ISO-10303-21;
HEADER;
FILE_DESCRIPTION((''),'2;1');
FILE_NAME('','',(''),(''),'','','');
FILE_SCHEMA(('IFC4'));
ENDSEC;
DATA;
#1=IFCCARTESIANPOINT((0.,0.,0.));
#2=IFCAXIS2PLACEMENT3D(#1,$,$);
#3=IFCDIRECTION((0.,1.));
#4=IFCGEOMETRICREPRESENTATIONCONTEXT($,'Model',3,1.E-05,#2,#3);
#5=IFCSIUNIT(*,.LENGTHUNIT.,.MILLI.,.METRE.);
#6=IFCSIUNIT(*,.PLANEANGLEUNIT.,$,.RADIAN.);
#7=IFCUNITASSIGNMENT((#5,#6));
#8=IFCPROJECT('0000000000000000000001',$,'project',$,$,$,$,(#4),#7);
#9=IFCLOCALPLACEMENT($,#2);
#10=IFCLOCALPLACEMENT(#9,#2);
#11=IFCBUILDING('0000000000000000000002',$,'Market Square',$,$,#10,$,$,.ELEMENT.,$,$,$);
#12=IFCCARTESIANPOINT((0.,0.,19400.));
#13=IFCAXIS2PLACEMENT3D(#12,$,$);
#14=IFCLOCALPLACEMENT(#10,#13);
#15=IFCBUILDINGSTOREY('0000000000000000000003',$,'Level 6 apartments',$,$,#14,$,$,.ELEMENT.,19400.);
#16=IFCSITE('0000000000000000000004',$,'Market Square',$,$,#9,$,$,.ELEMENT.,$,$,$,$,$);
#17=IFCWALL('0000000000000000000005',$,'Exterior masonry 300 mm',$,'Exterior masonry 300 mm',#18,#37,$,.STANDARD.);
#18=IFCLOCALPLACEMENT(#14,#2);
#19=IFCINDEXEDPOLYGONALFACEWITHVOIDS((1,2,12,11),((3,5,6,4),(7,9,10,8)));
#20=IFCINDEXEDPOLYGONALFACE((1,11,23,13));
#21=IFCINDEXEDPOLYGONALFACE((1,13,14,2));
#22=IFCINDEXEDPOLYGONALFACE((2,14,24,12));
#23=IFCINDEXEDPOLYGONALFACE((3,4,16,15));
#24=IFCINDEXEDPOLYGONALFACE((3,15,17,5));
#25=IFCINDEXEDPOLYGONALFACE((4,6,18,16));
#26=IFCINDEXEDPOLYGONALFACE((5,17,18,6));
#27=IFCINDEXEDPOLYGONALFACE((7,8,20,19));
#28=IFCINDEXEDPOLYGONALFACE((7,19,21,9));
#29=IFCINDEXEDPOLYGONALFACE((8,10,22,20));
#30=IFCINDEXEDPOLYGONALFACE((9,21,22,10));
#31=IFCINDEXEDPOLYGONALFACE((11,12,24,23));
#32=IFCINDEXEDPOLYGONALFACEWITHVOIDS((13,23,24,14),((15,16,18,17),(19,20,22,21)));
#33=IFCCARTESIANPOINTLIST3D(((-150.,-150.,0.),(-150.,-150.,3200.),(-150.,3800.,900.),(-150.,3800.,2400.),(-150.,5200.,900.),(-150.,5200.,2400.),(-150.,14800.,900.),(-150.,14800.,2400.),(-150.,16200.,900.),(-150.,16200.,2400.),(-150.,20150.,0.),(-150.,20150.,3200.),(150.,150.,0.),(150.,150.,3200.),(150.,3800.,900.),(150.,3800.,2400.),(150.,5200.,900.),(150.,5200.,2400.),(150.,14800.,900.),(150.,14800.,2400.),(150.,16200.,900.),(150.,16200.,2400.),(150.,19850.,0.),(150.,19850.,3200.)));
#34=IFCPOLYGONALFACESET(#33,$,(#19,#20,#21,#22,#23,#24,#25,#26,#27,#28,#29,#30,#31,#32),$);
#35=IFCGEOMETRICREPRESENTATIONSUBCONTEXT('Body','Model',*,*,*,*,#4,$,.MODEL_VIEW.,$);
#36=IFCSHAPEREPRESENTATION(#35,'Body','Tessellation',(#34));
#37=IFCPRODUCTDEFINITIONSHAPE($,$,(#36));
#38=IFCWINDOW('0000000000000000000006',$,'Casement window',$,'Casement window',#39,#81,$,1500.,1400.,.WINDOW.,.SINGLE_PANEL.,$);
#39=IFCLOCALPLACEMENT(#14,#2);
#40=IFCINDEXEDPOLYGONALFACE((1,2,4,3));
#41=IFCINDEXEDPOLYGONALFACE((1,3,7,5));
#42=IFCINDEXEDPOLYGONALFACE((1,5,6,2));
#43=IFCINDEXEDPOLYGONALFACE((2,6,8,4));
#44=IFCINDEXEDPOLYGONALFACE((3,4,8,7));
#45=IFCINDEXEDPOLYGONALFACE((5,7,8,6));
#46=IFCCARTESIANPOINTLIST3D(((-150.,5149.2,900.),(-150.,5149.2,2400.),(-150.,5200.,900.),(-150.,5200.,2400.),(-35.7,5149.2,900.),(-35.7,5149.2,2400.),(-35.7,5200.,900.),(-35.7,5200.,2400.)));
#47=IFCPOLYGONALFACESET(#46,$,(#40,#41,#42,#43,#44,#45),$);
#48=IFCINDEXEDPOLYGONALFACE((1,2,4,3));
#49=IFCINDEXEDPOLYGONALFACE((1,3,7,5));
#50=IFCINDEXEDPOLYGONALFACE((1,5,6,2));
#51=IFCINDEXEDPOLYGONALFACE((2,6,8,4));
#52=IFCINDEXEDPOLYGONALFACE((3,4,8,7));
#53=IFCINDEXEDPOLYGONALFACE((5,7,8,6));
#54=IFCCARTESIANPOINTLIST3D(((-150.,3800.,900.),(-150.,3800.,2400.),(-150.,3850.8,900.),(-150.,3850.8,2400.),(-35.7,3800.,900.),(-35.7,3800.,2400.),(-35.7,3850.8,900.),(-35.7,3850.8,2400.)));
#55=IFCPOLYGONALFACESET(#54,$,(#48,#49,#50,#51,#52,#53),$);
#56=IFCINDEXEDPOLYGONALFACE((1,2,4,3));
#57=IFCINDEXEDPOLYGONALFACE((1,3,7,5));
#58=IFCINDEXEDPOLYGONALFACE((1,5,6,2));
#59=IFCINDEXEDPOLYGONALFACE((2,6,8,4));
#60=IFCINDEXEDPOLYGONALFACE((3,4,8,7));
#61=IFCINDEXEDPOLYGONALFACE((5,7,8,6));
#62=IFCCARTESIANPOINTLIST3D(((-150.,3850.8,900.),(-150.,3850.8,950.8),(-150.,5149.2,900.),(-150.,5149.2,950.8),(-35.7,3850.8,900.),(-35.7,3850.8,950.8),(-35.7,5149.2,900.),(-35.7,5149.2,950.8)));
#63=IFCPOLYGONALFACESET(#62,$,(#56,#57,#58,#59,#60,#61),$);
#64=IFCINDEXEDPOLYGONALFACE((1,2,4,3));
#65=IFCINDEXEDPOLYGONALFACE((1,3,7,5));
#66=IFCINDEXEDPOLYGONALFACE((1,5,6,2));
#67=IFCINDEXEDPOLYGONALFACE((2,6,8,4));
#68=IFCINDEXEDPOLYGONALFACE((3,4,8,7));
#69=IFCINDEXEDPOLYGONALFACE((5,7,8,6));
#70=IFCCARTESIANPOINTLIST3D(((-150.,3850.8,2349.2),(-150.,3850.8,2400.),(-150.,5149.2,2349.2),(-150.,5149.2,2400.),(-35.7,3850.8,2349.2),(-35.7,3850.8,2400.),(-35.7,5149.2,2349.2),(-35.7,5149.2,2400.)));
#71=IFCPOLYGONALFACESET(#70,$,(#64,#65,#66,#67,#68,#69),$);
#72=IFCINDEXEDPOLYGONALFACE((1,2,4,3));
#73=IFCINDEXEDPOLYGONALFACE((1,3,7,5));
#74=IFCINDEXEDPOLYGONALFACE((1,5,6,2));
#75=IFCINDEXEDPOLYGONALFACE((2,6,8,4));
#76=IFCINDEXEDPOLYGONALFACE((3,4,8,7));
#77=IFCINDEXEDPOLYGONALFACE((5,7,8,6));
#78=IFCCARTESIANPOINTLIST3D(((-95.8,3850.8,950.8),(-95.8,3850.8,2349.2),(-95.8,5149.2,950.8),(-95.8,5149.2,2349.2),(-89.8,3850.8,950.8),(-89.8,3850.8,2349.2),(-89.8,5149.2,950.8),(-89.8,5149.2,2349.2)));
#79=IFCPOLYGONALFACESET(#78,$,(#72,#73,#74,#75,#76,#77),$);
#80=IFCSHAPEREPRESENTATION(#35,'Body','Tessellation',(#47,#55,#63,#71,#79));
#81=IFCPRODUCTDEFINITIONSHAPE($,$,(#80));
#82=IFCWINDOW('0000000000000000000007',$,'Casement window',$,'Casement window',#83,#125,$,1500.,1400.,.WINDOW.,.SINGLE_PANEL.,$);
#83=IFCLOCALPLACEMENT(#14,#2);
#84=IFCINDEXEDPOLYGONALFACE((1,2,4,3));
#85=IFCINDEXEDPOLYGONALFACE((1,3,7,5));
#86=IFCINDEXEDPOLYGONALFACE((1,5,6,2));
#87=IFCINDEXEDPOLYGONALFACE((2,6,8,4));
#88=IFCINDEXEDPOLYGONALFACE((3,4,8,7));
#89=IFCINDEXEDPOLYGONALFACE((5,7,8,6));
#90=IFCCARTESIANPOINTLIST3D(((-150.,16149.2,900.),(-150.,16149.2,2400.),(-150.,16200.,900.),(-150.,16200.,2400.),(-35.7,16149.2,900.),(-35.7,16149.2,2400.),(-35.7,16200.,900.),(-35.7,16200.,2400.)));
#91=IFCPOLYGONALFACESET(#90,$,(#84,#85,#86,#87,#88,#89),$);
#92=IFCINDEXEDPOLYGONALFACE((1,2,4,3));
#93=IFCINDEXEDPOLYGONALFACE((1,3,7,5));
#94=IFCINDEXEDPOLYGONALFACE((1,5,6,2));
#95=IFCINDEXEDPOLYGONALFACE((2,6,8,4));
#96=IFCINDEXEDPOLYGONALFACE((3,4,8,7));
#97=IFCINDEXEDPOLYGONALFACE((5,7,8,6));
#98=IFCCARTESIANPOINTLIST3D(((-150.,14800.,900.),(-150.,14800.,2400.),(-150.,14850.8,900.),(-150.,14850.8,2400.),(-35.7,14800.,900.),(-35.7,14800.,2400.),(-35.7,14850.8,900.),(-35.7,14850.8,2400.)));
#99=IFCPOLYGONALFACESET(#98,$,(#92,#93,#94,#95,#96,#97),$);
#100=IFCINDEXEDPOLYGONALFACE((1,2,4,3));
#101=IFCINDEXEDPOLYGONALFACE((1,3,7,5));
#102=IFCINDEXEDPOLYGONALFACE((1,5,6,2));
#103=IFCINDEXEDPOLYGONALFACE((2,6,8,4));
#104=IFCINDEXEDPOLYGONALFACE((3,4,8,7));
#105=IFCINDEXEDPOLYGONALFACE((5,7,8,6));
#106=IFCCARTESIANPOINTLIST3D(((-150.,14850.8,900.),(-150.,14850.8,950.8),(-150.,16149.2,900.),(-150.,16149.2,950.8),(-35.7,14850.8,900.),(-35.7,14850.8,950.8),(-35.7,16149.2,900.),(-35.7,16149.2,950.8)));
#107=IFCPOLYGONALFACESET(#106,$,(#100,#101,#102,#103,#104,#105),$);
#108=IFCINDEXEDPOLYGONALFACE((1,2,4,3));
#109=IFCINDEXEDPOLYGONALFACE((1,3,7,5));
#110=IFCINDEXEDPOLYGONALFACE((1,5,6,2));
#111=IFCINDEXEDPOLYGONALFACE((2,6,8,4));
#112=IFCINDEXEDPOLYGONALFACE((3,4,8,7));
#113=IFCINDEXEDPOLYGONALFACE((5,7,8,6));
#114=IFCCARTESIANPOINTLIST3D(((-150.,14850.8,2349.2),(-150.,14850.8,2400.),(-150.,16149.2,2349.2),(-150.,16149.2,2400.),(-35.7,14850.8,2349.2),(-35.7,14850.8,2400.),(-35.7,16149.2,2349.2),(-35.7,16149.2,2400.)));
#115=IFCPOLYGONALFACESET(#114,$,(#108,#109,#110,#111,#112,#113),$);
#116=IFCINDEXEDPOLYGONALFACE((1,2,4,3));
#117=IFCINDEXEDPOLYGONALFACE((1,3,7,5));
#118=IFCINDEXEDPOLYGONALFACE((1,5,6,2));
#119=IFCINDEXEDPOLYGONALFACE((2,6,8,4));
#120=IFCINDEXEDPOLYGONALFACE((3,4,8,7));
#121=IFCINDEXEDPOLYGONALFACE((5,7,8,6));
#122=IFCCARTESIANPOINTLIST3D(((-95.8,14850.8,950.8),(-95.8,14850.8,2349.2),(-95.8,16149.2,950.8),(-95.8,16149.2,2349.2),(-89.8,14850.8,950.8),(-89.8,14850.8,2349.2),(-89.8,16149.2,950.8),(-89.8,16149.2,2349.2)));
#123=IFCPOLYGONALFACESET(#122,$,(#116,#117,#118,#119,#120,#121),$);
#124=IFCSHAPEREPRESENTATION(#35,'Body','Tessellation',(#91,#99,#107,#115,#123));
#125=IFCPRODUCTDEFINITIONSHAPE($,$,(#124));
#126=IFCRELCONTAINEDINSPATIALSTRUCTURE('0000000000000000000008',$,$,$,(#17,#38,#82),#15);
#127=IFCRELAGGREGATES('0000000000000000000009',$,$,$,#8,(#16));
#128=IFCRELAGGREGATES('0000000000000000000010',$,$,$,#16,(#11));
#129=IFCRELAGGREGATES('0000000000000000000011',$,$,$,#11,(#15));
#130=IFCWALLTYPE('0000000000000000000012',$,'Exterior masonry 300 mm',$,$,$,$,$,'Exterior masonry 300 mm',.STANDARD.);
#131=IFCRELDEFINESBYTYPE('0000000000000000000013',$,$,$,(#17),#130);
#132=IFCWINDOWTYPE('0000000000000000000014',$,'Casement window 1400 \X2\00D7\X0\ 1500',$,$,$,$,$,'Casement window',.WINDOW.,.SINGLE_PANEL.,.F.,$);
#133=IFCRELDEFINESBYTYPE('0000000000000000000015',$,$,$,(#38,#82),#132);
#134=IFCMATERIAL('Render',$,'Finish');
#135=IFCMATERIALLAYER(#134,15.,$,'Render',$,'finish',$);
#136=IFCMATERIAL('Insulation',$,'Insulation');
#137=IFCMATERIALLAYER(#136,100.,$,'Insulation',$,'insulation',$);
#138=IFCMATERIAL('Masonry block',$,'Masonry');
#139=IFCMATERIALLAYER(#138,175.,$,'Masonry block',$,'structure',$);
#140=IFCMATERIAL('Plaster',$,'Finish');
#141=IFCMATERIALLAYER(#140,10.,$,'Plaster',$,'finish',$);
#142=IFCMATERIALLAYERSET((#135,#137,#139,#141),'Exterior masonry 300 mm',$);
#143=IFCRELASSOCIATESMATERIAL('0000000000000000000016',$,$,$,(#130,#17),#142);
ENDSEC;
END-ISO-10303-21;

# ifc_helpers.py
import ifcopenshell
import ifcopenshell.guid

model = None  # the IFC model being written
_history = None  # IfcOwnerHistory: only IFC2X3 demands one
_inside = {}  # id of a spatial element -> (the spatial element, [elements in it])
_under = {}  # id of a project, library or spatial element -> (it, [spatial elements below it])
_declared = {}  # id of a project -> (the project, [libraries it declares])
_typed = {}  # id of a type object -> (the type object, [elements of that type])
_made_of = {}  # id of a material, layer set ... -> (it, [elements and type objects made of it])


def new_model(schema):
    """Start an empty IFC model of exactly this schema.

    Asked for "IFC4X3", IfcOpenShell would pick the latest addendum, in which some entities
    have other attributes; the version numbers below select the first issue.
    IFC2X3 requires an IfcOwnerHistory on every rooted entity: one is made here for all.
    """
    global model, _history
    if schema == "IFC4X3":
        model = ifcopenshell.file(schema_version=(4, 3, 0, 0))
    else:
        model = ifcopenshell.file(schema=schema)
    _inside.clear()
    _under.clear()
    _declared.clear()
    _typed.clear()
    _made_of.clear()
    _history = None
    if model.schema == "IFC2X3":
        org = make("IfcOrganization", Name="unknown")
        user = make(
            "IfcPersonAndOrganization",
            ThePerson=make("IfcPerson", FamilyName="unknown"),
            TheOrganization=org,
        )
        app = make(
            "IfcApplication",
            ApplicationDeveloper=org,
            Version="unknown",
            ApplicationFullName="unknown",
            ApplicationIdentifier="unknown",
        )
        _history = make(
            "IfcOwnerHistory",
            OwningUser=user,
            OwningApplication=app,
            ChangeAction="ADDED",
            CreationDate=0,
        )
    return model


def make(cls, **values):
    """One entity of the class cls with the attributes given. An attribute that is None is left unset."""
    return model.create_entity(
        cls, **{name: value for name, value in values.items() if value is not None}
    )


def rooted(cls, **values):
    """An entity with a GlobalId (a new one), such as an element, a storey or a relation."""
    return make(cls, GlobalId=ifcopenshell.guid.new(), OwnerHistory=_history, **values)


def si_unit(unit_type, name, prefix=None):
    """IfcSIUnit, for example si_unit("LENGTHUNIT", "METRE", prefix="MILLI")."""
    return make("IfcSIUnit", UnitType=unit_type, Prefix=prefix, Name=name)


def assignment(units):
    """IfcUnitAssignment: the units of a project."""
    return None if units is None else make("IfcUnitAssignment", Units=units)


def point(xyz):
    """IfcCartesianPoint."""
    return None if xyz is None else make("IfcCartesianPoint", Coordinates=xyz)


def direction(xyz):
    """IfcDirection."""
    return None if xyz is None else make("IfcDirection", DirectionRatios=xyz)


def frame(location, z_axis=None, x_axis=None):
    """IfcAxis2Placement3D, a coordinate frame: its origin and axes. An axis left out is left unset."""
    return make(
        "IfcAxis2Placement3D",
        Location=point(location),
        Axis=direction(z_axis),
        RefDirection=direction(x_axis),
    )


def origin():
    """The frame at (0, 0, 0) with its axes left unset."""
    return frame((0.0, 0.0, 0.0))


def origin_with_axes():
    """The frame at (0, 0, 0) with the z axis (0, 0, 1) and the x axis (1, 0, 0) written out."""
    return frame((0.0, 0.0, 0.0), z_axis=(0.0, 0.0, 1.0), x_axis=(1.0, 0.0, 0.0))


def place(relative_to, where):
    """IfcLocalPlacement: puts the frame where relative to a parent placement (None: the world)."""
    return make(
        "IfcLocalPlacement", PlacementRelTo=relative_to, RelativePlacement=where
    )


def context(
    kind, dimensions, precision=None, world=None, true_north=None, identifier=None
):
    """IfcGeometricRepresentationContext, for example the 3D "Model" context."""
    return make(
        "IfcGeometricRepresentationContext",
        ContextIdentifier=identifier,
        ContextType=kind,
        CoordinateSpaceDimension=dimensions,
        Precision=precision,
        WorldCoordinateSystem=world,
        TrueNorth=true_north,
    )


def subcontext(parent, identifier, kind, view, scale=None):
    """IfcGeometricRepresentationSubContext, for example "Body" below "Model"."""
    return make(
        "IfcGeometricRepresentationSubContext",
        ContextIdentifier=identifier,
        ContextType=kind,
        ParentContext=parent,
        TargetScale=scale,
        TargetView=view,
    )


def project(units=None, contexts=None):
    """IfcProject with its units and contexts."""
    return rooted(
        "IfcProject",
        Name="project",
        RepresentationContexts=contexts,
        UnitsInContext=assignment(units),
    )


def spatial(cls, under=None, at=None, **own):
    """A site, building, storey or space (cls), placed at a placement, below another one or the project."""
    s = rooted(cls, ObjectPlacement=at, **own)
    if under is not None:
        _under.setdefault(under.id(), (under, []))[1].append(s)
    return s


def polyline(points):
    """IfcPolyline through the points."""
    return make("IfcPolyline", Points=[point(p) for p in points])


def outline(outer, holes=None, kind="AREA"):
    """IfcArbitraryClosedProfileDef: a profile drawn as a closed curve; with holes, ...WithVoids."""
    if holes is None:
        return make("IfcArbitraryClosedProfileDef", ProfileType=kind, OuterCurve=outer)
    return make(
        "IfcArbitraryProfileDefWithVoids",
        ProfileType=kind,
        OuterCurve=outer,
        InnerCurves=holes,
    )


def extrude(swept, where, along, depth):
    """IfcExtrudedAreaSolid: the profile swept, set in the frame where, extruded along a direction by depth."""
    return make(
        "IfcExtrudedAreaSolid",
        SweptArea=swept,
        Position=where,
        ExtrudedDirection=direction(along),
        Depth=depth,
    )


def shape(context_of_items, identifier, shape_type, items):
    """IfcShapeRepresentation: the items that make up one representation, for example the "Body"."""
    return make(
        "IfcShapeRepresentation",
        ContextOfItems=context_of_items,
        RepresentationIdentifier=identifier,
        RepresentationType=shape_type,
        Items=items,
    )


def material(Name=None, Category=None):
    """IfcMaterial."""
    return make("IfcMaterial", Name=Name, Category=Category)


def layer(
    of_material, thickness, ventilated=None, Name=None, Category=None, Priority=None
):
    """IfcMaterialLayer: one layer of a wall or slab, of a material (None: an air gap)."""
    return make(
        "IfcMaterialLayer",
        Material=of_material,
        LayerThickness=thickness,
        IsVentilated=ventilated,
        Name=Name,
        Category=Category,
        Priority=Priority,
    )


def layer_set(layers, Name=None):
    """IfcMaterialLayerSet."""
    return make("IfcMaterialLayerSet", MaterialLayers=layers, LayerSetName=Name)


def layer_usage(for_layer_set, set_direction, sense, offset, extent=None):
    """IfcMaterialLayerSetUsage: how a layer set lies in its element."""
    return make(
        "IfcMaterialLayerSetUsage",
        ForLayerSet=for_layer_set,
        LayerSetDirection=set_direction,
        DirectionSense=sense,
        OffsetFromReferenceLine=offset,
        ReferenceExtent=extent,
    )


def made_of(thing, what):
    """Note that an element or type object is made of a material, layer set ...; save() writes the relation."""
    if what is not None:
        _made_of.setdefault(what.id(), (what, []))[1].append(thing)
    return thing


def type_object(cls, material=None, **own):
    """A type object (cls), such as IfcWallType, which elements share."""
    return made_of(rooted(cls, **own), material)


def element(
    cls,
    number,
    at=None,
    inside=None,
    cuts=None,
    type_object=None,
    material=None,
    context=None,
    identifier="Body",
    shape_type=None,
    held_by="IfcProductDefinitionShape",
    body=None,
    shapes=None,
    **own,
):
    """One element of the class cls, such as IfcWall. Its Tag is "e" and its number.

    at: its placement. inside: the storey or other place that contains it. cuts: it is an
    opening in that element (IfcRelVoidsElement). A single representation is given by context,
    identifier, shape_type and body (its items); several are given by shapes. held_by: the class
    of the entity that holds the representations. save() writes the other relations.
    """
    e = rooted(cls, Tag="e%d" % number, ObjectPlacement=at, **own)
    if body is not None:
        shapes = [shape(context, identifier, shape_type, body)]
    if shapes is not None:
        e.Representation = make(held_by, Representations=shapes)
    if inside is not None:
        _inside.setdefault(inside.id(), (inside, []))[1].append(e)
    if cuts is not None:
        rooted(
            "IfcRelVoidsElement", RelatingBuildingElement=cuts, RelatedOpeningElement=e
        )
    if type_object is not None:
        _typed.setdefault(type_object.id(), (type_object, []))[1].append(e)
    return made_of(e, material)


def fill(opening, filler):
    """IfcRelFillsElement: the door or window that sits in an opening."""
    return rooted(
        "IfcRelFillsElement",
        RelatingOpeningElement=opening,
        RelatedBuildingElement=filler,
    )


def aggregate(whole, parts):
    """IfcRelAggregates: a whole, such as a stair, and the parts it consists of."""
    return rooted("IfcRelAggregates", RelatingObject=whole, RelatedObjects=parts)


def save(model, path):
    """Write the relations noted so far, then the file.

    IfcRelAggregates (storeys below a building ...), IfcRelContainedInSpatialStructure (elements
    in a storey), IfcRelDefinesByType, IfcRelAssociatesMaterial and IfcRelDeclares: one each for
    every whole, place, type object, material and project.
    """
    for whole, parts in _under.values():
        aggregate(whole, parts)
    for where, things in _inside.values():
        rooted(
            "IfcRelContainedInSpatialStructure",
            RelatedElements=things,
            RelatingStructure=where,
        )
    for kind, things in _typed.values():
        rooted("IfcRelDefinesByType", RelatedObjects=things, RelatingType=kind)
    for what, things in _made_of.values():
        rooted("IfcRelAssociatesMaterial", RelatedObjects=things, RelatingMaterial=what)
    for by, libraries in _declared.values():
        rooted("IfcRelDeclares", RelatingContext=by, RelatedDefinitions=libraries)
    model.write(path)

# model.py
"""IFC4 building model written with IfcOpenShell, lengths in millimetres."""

from ifc_helpers import new_model, si_unit, direction, frame, origin, origin_with_axes, place, context, subcontext, project, spatial, polyline, outline, extrude, material, layer, layer_set, layer_usage, type_object, element, fill, save


model = new_model("IFC4")

# Units and contexts
model_context = context("Model", 3, precision=1e-05, world=origin(), true_north=direction((0.0, 1.0)))
body_context = subcontext(model_context, "Body", "Model", "MODEL_VIEW")
ifc_project = project(units=[si_unit("LENGTHUNIT", "METRE", prefix="MILLI"), si_unit("PLANEANGLEUNIT", "RADIAN")], contexts=[model_context])

# Site, building, storey
site_placement = place(None, origin())
site = spatial("IfcSite", under=ifc_project, at=site_placement, Name="Market Square", CompositionType="ELEMENT")
building_placement = place(site_placement, origin())
building = spatial("IfcBuilding", under=site, at=building_placement, Name="Market Square", CompositionType="ELEMENT")
storey_placement = place(building_placement, frame((0.0, 0.0, 19400.0)))
storey = spatial("IfcBuildingStorey", under=building, at=storey_placement, Name="Level 6 apartments", CompositionType="ELEMENT", Elevation=19400.0)

# Wall, openings, windows
ifc_material_1 = material(Name="Render", Category="Finish")
ifc_layer_1 = layer(ifc_material_1, 15.0, Name="Render", Category="finish")
ifc_material_2 = material(Name="Insulation", Category="Insulation")
ifc_layer_2 = layer(ifc_material_2, 100.0, Name="Insulation", Category="insulation")
ifc_material_3 = material(Name="Masonry block", Category="Masonry")
ifc_layer_3 = layer(ifc_material_3, 175.0, Name="Masonry block", Category="structure")
ifc_material_4 = material(Name="Plaster", Category="Finish")
ifc_layer_4 = layer(ifc_material_4, 10.0, Name="Plaster", Category="finish")
ifc_layer_set_1 = layer_set([ifc_layer_1, ifc_layer_2, ifc_layer_3, ifc_layer_4], Name="Exterior masonry 300 mm")
ifc_layer_usage_1 = layer_usage(ifc_layer_set_1, "AXIS2", "POSITIVE", -150.0)
wall_type_1 = type_object("IfcWallType", Name="Exterior masonry 300 mm", ElementType="Exterior masonry 300 mm", PredefinedType="STANDARD", material=ifc_layer_set_1)
wall_1_placement = place(storey_placement, frame((0.0, 20000.0, 0.0), z_axis=(0.0, 0.0, 1.0), x_axis=(0.0, -1.0, 0.0)))
wall_1 = element("IfcWall", 1, at=wall_1_placement, inside=storey, type_object=wall_type_1, material=ifc_layer_usage_1, Name="Exterior masonry 300 mm", ObjectType="Exterior masonry 300 mm", PredefinedType="STANDARD", context=body_context, shape_type="SweptSolid", body=[
    extrude(outline(polyline([(-150.0, -150.0), (20150.0, -150.0), (19850.0, 150.0), (150.0, 150.0), (-150.0, -150.0)])), origin(), (0.0, 0.0, 1.0), 3200.0),
])
opening_1_placement = place(wall_1_placement, frame((14800.0, 0.0, 900.0), z_axis=(0.0, 0.0, 1.0), x_axis=(1.0, 0.0, 0.0)))
opening_1 = element("IfcOpeningElement", 2, at=opening_1_placement, cuts=wall_1, PredefinedType="OPENING", context=body_context, shape_type="SweptSolid", body=[
    extrude(outline(polyline([(0.0, -160.0), (1400.0, -160.0), (1400.0, 160.0), (0.0, 160.0), (0.0, -160.0)])), origin(), (0.0, 0.0, 1.0), 1500.0),
])
opening_2_placement = place(wall_1_placement, frame((3800.0, 0.0, 900.0), z_axis=(0.0, 0.0, 1.0), x_axis=(1.0, 0.0, 0.0)))
opening_2 = element("IfcOpeningElement", 3, at=opening_2_placement, cuts=wall_1, PredefinedType="OPENING", context=body_context, shape_type="SweptSolid", body=[
    extrude(outline(polyline([(0.0, -160.0), (1400.0, -160.0), (1400.0, 160.0), (0.0, 160.0), (0.0, -160.0)])), origin(), (0.0, 0.0, 1.0), 1500.0),
])
window_type = type_object("IfcWindowType", Name="Casement window 1400 × 1500", ElementType="Casement window", ParameterTakesPrecedence=False, PartitioningType="SINGLE_PANEL", PredefinedType="WINDOW")
window_1_placement = place(opening_1_placement, origin_with_axes())
window_1 = element("IfcWindow", 4, at=window_1_placement, inside=storey, type_object=window_type, Name="Casement window", ObjectType="Casement window", OverallHeight=1500.0, OverallWidth=1400.0, PartitioningType="SINGLE_PANEL", PredefinedType="WINDOW", context=body_context, shape_type="SweptSolid", body=[
    extrude(outline(polyline([(0.0, -150.0), (50.8, -150.0), (50.8, -35.7), (0.0, -35.7), (0.0, -150.0)])), origin(), (0.0, 0.0, 1.0), 1500.0),
    extrude(outline(polyline([(1349.2, -150.0), (1400.0, -150.0), (1400.0, -35.7), (1349.2, -35.7), (1349.2, -150.0)])), origin(), (0.0, 0.0, 1.0), 1500.0),
    extrude(outline(polyline([(50.8, -150.0), (1349.2, -150.0), (1349.2, -35.7), (50.8, -35.7), (50.8, -150.0)])), origin(), (0.0, 0.0, 1.0), 50.8),
    extrude(outline(polyline([(50.8, -150.0), (1349.2, -150.0), (1349.2, -35.7), (50.8, -35.7), (50.8, -150.0)])), frame((0.0, 0.0, 1449.2)), (0.0, 0.0, 1.0), 50.8),
    extrude(outline(polyline([(50.8, -95.8), (1349.2, -95.8), (1349.2, -89.8), (50.8, -89.8), (50.8, -95.8)])), frame((0.0, 0.0, 50.8)), (0.0, 0.0, 1.0), 1398.4),
])
fill(opening_1, window_1)
window_2_placement = place(opening_2_placement, origin_with_axes())
window_2 = element("IfcWindow", 5, at=window_2_placement, inside=storey, type_object=window_type, Name="Casement window", ObjectType="Casement window", OverallHeight=1500.0, OverallWidth=1400.0, PartitioningType="SINGLE_PANEL", PredefinedType="WINDOW", context=body_context, shape_type="SweptSolid", body=[
    extrude(outline(polyline([(0.0, -150.0), (50.8, -150.0), (50.8, -35.7), (0.0, -35.7), (0.0, -150.0)])), origin(), (0.0, 0.0, 1.0), 1500.0),
    extrude(outline(polyline([(1349.2, -150.0), (1400.0, -150.0), (1400.0, -35.7), (1349.2, -35.7), (1349.2, -150.0)])), origin(), (0.0, 0.0, 1.0), 1500.0),
    extrude(outline(polyline([(50.8, -150.0), (1349.2, -150.0), (1349.2, -35.7), (50.8, -35.7), (50.8, -150.0)])), origin(), (0.0, 0.0, 1.0), 50.8),
    extrude(outline(polyline([(50.8, -150.0), (1349.2, -150.0), (1349.2, -35.7), (50.8, -35.7), (50.8, -150.0)])), frame((0.0, 0.0, 1449.2)), (0.0, 0.0, 1.0), 50.8),
    extrude(outline(polyline([(50.8, -95.8), (1349.2, -95.8), (1349.2, -89.8), (50.8, -89.8), (50.8, -95.8)])), frame((0.0, 0.0, 50.8)), (0.0, 0.0, 1.0), 1398.4),
])
fill(opening_2, window_2)

save(model, "model.ifc")
